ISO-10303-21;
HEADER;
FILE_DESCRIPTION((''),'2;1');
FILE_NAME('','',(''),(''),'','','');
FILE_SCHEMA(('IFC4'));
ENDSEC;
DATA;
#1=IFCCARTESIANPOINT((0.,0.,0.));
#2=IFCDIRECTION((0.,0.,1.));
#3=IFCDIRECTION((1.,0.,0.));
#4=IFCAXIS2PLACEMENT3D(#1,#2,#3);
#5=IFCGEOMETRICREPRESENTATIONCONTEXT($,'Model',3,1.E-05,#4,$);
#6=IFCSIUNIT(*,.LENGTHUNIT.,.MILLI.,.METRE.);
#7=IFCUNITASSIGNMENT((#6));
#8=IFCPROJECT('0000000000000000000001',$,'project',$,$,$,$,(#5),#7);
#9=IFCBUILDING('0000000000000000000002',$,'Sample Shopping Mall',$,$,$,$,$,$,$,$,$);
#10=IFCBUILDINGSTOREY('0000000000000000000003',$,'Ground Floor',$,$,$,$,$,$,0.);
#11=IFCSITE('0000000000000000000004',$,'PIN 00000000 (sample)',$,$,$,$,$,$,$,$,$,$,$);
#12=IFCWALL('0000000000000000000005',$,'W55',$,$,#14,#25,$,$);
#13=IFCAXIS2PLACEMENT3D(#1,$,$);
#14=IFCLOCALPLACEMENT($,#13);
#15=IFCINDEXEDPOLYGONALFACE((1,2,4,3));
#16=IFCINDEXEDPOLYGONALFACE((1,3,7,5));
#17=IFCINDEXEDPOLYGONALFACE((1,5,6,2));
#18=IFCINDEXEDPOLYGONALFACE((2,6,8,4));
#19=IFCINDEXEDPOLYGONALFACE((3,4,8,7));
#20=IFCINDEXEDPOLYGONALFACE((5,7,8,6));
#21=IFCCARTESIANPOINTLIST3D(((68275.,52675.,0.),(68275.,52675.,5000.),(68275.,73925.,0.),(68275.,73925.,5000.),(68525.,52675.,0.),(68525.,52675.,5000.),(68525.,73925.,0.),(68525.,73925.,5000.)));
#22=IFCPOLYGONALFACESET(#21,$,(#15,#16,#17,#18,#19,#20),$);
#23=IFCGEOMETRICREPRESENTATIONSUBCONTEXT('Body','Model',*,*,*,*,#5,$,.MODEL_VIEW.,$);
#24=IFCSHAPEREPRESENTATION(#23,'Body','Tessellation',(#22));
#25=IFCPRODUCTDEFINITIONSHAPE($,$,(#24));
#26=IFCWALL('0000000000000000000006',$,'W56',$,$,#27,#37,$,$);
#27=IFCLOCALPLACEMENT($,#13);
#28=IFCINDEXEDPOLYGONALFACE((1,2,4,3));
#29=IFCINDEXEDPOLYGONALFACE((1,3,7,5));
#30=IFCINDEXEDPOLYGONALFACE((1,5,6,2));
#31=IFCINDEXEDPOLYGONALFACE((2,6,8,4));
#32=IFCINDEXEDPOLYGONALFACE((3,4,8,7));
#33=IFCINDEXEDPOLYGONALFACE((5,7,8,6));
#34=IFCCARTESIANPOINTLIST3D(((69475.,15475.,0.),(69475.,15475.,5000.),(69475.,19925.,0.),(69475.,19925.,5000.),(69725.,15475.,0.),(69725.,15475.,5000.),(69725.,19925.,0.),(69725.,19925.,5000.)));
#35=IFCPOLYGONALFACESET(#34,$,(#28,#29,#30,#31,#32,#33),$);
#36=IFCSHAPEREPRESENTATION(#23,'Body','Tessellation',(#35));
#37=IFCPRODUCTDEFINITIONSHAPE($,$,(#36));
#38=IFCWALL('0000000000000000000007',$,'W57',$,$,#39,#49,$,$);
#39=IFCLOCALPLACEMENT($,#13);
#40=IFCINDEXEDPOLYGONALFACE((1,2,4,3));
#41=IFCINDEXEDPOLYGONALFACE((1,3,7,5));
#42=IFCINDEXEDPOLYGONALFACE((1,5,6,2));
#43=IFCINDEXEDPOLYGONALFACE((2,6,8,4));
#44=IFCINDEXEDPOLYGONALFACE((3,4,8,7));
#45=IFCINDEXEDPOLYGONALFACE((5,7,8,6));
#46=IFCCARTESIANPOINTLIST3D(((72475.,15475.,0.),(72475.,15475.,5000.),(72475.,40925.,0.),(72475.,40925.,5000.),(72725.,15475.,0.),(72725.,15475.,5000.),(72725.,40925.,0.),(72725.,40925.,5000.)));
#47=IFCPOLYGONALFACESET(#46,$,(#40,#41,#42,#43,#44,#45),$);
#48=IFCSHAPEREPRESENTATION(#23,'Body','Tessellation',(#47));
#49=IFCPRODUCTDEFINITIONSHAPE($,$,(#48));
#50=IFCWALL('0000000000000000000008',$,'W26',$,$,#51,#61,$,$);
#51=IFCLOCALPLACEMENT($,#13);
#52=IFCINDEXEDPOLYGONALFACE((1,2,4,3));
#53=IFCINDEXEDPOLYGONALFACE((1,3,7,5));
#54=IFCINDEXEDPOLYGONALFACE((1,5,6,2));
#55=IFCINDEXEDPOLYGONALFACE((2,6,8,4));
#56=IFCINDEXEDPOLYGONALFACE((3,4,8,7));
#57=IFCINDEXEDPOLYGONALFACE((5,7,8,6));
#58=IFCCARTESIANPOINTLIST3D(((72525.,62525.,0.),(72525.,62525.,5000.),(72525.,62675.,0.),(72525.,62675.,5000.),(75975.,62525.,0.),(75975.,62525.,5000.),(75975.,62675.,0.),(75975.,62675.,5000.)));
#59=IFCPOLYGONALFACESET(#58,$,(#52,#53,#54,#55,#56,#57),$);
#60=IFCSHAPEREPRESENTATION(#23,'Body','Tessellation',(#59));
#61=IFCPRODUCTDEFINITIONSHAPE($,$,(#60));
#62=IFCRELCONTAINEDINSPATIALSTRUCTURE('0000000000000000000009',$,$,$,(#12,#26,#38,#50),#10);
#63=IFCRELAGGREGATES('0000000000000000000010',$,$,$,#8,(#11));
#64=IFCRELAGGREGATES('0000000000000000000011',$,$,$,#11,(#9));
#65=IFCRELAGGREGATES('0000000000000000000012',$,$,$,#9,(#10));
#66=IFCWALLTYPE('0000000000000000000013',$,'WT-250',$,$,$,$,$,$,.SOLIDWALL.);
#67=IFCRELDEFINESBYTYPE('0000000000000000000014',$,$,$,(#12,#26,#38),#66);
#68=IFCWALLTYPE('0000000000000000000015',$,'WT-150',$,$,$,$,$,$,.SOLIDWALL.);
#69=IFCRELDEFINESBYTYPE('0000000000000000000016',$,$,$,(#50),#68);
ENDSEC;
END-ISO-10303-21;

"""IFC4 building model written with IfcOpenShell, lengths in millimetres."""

from ifc_helpers import new_model, si_unit, frame, origin_with_axes, place, context, subcontext, project, spatial, indexed_curve, outline, extrude, type_object, element, save


model = new_model("IFC4")

# Units and contexts
model_context = context("Model", 3, precision=1e-05, world=origin_with_axes())
body_context = subcontext(model_context, "Body", "Model", "MODEL_VIEW")
ifc_project = project(units=[si_unit("LENGTHUNIT", "METRE", prefix="MILLI")], contexts=[model_context])

# Site, building, storey
site = spatial("IfcSite", under=ifc_project, Name="PIN 00000000 (sample)")
building = spatial("IfcBuilding", under=site, Name="Sample Shopping Mall")
storey = spatial("IfcBuildingStorey", under=building, Name="Ground Floor", Elevation=0.0)

# Shared definitions
wall_type_1 = type_object("IfcWallType", Name="WT-250", PredefinedType="SOLIDWALL")

# Walls
wall_1_placement = place(None, frame((68525.0, 52675.0, 0.0), z_axis=(0.0, 0.0, 1.0), x_axis=(0.0, 1.0, 0.0)))
element("IfcWall", 1, at=wall_1_placement, inside=storey, type_object=wall_type_1, Name="W55", context=body_context, shape_type="SweptSolid", body=[
    extrude(outline(indexed_curve([(0.0, 0.0), (0.0, 250.0), (21250.0, 250.0), (21250.0, 0.0), (0.0, 0.0)], self_intersect=False)), origin_with_axes(), (0.0, 0.0, 1.0), 5000.0),
])
wall_2_placement = place(None, frame((69725.0, 15475.0, 0.0), z_axis=(0.0, 0.0, 1.0), x_axis=(0.0, 1.0, 0.0)))
element("IfcWall", 2, at=wall_2_placement, inside=storey, type_object=wall_type_1, Name="W56", context=body_context, shape_type="SweptSolid", body=[
    extrude(outline(indexed_curve([(0.0, 0.0), (0.0, 250.0), (4450.0, 250.0), (4450.0, 0.0), (0.0, 0.0)], self_intersect=False)), origin_with_axes(), (0.0, 0.0, 1.0), 5000.0),
])
wall_3_placement = place(None, frame((72725.0, 15475.0, 0.0), z_axis=(0.0, 0.0, 1.0), x_axis=(0.0, 1.0, 0.0)))
element("IfcWall", 3, at=wall_3_placement, inside=storey, type_object=wall_type_1, Name="W57", context=body_context, shape_type="SweptSolid", body=[
    extrude(outline(indexed_curve([(0.0, 0.0), (0.0, 250.0), (25450.0, 250.0), (25450.0, 0.0), (0.0, 0.0)], self_intersect=False)), origin_with_axes(), (0.0, 0.0, 1.0), 5000.0),
])
wall_type_2 = type_object("IfcWallType", Name="WT-150", PredefinedType="SOLIDWALL")
wall_4_placement = place(None, frame((72525.0, 62525.0, 0.0), z_axis=(0.0, 0.0, 1.0), x_axis=(1.0, 0.0, 0.0)))
element("IfcWall", 4, at=wall_4_placement, inside=storey, type_object=wall_type_2, Name="W26", context=body_context, shape_type="SweptSolid", body=[
    extrude(outline(indexed_curve([(0.0, 0.0), (0.0, 150.0), (3450.0, 150.0), (3450.0, 0.0), (0.0, 0.0)], self_intersect=False)), origin_with_axes(), (0.0, 0.0, 1.0), 5000.0),
])

save(model, "model.ifc")
